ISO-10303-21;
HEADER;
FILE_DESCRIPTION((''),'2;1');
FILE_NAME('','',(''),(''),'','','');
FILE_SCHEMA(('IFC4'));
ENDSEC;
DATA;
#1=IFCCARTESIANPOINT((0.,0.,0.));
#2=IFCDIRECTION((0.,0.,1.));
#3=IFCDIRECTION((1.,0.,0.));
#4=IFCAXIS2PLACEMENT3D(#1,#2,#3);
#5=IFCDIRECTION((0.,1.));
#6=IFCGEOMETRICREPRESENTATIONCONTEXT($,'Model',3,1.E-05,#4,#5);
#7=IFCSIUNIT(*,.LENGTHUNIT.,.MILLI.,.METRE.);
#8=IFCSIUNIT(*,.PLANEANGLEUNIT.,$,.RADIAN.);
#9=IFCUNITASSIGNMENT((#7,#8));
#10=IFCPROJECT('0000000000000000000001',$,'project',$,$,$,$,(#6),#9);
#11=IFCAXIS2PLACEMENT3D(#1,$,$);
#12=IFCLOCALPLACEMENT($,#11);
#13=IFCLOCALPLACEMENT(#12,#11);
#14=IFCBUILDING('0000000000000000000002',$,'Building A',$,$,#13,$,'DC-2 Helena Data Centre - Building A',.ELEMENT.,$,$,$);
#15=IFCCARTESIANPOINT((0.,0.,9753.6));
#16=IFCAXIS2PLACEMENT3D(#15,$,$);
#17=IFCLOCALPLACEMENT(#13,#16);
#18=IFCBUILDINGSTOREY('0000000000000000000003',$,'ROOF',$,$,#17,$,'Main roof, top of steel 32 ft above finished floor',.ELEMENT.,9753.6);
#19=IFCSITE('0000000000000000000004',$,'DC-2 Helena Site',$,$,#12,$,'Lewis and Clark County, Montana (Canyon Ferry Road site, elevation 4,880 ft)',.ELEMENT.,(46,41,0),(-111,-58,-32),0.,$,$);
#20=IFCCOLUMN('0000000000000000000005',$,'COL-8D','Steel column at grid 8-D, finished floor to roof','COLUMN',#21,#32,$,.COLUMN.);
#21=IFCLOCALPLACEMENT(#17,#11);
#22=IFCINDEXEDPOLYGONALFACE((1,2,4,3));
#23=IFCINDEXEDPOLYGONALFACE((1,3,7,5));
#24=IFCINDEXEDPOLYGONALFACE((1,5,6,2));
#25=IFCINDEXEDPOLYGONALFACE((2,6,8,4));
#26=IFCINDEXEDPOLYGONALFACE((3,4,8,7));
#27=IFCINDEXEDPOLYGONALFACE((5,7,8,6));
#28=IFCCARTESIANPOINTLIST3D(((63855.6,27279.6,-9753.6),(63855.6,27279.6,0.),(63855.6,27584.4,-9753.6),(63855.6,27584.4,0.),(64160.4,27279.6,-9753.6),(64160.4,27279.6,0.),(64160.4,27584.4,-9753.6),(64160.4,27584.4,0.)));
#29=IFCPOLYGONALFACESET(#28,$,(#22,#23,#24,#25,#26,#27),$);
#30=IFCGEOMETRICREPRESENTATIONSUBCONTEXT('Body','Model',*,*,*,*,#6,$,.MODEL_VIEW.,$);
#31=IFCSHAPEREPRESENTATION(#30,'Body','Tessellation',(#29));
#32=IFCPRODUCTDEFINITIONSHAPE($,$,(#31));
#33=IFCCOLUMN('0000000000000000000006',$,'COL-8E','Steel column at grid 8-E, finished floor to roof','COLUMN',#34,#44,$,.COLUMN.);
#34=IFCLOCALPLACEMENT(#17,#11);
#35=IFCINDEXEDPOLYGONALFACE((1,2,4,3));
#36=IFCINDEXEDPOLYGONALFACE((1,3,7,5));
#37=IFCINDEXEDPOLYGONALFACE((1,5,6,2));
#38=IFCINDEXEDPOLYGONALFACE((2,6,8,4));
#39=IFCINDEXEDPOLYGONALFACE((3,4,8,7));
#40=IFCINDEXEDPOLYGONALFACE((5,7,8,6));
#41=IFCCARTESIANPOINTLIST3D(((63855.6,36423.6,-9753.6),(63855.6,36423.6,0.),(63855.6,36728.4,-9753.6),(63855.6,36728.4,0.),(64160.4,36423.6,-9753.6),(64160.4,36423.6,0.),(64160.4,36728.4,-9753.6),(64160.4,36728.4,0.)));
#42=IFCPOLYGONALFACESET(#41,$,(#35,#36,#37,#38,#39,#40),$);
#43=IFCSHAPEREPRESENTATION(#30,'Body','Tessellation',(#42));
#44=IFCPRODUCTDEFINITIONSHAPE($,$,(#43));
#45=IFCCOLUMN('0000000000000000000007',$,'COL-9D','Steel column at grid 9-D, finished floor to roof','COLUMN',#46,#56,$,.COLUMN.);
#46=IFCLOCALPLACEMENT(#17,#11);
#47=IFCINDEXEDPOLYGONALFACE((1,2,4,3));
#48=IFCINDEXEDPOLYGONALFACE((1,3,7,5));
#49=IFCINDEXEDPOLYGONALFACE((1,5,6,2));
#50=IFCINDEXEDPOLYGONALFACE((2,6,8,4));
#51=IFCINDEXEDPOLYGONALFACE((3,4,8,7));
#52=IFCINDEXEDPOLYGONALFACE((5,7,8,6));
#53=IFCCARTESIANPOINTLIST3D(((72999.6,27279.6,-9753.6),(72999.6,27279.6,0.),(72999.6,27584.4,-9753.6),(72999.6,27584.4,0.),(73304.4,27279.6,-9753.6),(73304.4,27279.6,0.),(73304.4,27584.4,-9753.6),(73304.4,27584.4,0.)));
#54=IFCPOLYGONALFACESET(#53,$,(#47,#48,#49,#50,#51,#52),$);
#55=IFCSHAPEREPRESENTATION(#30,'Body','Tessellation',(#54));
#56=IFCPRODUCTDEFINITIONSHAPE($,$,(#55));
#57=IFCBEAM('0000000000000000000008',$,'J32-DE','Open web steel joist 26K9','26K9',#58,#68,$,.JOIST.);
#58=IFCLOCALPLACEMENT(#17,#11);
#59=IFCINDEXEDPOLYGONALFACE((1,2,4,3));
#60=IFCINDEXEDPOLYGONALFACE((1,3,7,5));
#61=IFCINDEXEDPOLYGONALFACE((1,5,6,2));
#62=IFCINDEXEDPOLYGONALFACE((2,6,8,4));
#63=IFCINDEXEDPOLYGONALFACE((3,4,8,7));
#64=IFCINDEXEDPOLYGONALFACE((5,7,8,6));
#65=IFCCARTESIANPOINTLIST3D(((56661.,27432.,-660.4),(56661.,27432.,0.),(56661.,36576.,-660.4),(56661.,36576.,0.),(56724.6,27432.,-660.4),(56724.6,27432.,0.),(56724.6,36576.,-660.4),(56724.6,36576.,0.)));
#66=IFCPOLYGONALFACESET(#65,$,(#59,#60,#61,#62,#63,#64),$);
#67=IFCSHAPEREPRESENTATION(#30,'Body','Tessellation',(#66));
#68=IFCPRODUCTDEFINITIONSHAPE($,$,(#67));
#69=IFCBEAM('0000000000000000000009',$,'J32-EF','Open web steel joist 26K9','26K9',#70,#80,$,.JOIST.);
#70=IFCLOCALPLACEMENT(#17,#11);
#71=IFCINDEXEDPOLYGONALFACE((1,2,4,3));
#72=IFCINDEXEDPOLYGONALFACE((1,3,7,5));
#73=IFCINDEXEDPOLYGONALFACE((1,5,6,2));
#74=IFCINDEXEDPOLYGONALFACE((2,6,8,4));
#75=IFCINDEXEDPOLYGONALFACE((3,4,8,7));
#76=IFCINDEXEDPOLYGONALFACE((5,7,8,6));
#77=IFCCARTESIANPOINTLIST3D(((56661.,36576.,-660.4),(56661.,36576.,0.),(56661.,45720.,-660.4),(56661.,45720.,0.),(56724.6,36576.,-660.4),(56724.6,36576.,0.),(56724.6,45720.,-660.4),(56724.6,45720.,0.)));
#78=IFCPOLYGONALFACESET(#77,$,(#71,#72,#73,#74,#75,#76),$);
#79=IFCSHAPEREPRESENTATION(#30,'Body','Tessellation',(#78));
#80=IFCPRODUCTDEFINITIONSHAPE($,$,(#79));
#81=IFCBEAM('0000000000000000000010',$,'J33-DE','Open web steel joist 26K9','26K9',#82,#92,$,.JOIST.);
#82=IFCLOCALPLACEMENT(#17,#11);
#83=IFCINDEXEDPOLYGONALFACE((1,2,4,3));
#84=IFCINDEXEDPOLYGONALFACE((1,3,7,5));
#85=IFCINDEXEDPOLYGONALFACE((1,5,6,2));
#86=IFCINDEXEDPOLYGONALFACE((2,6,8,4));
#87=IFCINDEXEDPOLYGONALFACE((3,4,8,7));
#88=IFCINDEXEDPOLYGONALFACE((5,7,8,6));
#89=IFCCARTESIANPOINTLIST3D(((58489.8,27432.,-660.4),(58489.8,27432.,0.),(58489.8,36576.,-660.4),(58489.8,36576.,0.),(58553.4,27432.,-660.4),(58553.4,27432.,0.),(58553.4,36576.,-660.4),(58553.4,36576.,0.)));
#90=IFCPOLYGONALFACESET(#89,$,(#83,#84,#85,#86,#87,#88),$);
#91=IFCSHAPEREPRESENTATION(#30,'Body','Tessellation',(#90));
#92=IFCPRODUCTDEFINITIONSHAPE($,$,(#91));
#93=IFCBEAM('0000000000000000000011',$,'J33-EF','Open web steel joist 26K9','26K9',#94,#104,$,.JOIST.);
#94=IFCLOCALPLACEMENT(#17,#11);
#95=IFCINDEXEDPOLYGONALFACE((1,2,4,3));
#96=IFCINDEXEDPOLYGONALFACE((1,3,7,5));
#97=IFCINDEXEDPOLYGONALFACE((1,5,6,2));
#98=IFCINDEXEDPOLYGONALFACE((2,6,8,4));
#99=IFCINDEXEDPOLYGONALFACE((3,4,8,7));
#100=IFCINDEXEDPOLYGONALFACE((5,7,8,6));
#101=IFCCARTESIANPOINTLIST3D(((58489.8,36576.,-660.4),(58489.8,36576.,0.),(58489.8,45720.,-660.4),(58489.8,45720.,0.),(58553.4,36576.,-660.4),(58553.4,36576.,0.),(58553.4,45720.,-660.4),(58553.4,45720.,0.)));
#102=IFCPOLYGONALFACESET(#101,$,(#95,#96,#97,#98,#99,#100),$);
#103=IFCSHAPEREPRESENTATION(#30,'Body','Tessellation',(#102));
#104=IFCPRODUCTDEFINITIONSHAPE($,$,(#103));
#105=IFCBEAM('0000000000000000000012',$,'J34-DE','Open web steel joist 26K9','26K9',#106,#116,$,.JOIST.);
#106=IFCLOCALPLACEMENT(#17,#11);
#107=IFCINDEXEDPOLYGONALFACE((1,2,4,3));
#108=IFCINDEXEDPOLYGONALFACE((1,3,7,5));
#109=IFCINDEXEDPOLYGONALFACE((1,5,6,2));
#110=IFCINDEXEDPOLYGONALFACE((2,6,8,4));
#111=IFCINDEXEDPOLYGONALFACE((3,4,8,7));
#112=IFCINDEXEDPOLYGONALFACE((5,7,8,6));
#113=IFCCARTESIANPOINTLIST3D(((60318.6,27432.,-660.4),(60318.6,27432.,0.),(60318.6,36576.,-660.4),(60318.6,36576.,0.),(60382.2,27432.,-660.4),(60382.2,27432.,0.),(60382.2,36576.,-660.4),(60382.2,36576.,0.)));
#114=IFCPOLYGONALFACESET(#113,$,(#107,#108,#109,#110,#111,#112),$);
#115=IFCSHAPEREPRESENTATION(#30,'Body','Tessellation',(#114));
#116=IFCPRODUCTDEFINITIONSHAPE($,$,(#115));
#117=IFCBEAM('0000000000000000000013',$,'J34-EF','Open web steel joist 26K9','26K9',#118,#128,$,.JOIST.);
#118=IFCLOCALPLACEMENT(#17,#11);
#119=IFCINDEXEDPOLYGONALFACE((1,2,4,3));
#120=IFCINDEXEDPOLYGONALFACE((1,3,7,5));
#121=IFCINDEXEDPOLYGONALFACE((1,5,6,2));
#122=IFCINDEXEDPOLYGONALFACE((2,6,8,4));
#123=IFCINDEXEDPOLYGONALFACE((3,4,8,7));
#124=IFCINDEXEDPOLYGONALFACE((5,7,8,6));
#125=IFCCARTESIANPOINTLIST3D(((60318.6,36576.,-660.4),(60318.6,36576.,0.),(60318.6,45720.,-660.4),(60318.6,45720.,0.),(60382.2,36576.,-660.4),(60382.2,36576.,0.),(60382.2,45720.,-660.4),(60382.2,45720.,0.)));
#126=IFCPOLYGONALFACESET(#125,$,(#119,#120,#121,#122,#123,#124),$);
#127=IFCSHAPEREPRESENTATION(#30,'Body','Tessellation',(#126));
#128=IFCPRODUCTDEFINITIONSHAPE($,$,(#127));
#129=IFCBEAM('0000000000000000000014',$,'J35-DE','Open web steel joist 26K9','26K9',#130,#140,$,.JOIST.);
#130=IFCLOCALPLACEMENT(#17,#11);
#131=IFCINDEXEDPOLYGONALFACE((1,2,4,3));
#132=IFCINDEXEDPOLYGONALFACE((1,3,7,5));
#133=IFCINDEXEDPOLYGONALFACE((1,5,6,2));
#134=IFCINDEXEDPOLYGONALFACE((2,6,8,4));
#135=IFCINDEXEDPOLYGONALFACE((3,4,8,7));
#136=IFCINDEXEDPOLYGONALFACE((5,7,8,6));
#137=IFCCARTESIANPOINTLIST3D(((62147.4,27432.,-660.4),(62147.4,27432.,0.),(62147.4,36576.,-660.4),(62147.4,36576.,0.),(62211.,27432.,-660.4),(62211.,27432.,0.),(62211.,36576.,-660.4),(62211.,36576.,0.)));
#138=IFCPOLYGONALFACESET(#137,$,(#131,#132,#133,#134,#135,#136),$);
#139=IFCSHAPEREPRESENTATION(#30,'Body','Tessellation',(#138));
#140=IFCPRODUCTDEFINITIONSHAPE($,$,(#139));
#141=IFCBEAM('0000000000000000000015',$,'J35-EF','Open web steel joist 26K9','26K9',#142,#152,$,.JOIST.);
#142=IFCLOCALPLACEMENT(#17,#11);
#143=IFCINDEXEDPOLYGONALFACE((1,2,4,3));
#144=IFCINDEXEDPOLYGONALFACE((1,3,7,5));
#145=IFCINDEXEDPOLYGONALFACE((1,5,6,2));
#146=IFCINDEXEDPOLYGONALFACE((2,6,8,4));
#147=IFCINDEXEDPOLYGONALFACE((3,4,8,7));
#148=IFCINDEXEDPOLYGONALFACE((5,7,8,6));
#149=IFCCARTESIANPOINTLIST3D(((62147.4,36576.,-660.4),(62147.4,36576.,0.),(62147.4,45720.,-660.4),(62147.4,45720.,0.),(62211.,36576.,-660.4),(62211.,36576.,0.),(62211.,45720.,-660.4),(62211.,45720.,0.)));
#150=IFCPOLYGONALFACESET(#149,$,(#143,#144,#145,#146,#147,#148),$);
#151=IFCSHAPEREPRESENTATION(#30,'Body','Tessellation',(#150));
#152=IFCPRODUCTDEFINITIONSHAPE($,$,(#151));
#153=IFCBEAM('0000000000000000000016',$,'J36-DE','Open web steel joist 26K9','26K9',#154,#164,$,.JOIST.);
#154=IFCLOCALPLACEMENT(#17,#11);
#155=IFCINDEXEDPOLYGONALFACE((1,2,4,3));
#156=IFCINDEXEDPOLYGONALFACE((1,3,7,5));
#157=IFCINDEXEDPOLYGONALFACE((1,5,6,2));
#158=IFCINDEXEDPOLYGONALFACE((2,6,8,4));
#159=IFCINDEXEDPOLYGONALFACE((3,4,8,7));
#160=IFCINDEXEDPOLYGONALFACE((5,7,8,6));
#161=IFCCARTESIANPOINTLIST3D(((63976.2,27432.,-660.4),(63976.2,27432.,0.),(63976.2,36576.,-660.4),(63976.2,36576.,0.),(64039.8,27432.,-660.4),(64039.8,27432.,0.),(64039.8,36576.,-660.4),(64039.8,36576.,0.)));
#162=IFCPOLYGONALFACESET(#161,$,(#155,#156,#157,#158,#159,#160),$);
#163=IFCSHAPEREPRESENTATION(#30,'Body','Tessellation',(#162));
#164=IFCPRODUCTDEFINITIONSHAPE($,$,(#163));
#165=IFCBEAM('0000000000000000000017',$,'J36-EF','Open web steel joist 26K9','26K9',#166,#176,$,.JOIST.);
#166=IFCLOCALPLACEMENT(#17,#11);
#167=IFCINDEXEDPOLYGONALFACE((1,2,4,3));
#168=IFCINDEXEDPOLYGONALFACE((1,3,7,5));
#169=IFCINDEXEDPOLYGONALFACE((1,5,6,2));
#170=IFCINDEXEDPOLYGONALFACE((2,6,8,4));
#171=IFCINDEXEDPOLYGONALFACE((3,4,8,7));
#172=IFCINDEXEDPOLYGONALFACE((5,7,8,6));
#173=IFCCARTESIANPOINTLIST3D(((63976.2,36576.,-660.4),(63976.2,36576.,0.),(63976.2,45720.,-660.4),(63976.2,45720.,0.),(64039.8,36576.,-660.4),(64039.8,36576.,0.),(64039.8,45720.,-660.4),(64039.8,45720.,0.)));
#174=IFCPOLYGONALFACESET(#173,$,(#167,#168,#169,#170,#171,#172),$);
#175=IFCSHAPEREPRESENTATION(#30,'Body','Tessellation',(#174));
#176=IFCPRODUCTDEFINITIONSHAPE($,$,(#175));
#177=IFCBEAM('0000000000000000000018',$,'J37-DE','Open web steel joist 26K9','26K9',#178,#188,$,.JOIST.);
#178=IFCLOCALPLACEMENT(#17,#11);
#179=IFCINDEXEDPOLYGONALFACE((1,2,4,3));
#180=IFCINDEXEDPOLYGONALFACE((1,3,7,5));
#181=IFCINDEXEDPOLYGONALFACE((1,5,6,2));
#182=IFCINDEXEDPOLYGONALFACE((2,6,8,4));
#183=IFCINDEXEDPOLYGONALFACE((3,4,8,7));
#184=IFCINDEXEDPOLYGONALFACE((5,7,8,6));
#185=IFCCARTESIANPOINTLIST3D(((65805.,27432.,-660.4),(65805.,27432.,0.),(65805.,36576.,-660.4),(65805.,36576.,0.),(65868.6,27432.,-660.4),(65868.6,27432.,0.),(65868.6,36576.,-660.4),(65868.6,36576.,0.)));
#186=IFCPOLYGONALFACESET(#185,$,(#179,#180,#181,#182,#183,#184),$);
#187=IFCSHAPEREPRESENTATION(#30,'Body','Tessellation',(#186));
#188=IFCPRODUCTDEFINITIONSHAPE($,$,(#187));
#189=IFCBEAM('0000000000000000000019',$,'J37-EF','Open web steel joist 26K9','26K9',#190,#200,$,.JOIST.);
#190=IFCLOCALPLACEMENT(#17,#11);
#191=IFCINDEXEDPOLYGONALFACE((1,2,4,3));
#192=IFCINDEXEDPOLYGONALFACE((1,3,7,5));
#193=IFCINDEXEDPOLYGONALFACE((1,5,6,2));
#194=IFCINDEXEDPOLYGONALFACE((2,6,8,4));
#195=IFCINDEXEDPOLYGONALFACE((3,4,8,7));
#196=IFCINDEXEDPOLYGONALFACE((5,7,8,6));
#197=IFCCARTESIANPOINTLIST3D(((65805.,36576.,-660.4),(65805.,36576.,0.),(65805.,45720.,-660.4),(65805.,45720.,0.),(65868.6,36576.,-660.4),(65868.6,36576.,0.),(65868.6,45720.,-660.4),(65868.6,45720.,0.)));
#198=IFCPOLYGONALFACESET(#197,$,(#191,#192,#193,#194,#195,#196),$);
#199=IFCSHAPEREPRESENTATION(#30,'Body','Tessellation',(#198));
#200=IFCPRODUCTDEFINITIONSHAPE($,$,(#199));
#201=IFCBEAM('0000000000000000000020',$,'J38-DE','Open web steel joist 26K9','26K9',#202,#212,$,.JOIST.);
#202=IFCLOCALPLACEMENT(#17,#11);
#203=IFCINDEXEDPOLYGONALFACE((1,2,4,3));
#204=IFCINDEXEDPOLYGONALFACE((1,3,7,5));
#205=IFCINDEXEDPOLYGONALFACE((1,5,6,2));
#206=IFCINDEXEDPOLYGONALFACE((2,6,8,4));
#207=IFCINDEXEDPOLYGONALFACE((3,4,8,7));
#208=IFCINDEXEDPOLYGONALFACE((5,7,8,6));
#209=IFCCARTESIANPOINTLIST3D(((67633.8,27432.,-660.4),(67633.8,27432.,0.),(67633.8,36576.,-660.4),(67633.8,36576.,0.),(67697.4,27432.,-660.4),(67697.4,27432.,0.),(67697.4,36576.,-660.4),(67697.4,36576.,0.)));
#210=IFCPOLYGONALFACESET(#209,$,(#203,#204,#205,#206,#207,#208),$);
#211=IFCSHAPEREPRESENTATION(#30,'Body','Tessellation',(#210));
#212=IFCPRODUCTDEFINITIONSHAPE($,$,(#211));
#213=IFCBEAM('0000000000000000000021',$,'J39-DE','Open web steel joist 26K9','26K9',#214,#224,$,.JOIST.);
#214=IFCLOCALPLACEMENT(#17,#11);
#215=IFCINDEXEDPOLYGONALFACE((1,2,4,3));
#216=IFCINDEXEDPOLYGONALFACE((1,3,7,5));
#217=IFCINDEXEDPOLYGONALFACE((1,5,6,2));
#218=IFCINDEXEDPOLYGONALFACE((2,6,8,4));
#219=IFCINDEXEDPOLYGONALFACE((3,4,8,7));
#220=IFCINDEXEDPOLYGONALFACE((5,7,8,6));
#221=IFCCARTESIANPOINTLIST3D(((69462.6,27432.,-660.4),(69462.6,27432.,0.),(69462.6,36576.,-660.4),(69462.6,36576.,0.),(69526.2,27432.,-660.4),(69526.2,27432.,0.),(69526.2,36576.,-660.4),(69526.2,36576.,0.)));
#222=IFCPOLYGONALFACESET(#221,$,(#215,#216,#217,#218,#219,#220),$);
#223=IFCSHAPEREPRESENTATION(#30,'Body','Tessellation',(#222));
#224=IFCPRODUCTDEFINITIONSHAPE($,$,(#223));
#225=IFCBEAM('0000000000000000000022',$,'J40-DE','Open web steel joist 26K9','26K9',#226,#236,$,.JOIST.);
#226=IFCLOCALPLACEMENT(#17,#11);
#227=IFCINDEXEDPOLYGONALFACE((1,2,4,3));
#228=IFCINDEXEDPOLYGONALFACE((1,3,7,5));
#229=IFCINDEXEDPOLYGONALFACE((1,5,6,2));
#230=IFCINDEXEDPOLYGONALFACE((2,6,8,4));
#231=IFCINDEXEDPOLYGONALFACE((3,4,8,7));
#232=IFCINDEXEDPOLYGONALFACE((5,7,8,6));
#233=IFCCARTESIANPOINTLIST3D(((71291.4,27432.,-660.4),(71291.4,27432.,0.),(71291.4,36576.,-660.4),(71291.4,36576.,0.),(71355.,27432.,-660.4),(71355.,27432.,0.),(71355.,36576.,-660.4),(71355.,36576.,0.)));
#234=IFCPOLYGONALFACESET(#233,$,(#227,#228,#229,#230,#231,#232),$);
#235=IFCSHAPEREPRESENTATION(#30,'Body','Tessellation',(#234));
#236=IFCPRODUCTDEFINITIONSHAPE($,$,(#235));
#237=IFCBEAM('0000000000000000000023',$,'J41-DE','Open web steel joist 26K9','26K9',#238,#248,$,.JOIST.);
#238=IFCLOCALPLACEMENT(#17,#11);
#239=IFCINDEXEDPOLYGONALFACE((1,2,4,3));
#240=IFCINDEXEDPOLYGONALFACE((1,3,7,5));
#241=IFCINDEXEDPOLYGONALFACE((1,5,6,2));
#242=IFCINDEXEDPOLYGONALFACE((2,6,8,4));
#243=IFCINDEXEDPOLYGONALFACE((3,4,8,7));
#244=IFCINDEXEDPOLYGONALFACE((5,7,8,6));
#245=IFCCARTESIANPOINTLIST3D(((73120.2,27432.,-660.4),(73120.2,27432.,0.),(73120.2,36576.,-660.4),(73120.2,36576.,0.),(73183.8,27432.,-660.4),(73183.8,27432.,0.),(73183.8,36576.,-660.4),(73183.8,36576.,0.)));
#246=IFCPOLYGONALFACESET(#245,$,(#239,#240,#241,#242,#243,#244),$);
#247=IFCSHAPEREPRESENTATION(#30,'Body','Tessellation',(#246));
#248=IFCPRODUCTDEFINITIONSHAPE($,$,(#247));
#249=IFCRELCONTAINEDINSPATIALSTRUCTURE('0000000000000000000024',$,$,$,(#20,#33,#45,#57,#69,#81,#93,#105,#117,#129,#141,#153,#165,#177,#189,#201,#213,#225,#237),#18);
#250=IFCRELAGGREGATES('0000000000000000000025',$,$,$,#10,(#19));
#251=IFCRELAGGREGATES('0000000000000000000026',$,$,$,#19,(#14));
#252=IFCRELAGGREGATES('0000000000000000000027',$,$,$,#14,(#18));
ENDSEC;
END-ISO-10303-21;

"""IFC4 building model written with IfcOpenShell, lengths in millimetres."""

from ifc_helpers import new_model, si_unit, direction, frame, origin, origin_with_axes, origin_2d, place, context, subcontext, project, spatial, rectangle, extrude, element, save


model = new_model("IFC4")

# Units and contexts
model_context = context("Model", 3, precision=1e-05, world=origin_with_axes(), true_north=direction((0.0, 1.0)))
body_context = subcontext(model_context, "Body", "Model", "MODEL_VIEW")
ifc_project = project(units=[si_unit("LENGTHUNIT", "METRE", prefix="MILLI"), si_unit("PLANEANGLEUNIT", "RADIAN")], contexts=[model_context])

# Site, building, storey
site_placement = place(None, origin())
site = spatial("IfcSite", under=ifc_project, at=site_placement, Name="DC-2 Helena Site", LongName="Lewis and Clark County, Montana (Canyon Ferry Road site, elevation 4,880 ft)", CompositionType="ELEMENT", RefLatitude=(46, 41, 0), RefLongitude=(-111, -58, -32), RefElevation=0.0)
building_placement = place(site_placement, origin())
building = spatial("IfcBuilding", under=site, at=building_placement, Name="Building A", LongName="DC-2 Helena Data Centre - Building A", CompositionType="ELEMENT")
storey_placement = place(building_placement, frame((0.0, 0.0, 9753.6)))
storey = spatial("IfcBuildingStorey", under=building, at=storey_placement, Name="ROOF", LongName="Main roof, top of steel 32 ft above finished floor", CompositionType="ELEMENT", Elevation=9753.6)

# Columns
for number, where, name, description in (
    (1, (64008.0, 27432.0, -9753.6), "COL-8D", "Steel column at grid 8-D, finished floor to roof"),
    (2, (64008.0, 36576.0, -9753.6), "COL-8E", "Steel column at grid 8-E, finished floor to roof"),
):
    element("IfcColumn", number, at=place(storey_placement, frame(where)), inside=storey, Name=name, Description=description, ObjectType="COLUMN", PredefinedType="COLUMN", context=body_context, shape_type="SweptSolid", body=[
        extrude(rectangle(XDim=304.8, YDim=304.8, at=origin_2d()), origin(), (0.0, 0.0, 1.0), 9753.6),
    ])
placement_1 = place(storey_placement, frame((73152.0, 27432.0, -9753.6)))
element("IfcColumn", 3, at=placement_1, inside=storey, Name="COL-9D", Description="Steel column at grid 9-D, finished floor to roof", ObjectType="COLUMN", PredefinedType="COLUMN", context=body_context, shape_type="SweptSolid", body=[
    extrude(rectangle(XDim=304.8, YDim=304.8, at=origin_2d()), origin(), (0.0, 0.0, 1.0), 9753.6),
])

# Beams
for number, where, name in (
    (4, (56692.8, 27432.0, 0.0), "J32-DE"),
    (5, (56692.8, 36576.0, 0.0), "J32-EF"),
    (6, (58521.6, 27432.0, 0.0), "J33-DE"),
    (7, (58521.6, 36576.0, 0.0), "J33-EF"),
    (8, (60350.4, 27432.0, 0.0), "J34-DE"),
    (9, (60350.4, 36576.0, 0.0), "J34-EF"),
    (10, (62179.2, 27432.0, 0.0), "J35-DE"),
    (11, (62179.2, 36576.0, 0.0), "J35-EF"),
):
    element("IfcBeam", number, at=place(storey_placement, frame(where)), inside=storey, Name=name, Description="Open web steel joist 26K9", ObjectType="26K9", PredefinedType="JOIST", context=body_context, shape_type="SweptSolid", body=[
        extrude(rectangle(XDim=63.5, YDim=660.4, at=origin_2d()), frame((0.0, 0.0, -330.2), z_axis=(0.0, 1.0, 0.0), x_axis=(1.0, 0.0, 0.0)), (0.0, 0.0, 1.0), 9144.0),
    ])
placement_2 = place(storey_placement, frame((64008.0, 27432.0, 0.0)))
element("IfcBeam", 12, at=placement_2, inside=storey, Name="J36-DE", Description="Open web steel joist 26K9", ObjectType="26K9", PredefinedType="JOIST", context=body_context, shape_type="SweptSolid", body=[
    extrude(rectangle(XDim=63.5, YDim=660.4, at=origin_2d()), frame((0.0, 0.0, -330.2), z_axis=(0.0, 1.0, 0.0), x_axis=(1.0, 0.0, 0.0)), (0.0, 0.0, 1.0), 9144.0),
])
placement_3 = place(storey_placement, frame((64008.0, 36576.0, 0.0)))
element("IfcBeam", 13, at=placement_3, inside=storey, Name="J36-EF", Description="Open web steel joist 26K9", ObjectType="26K9", PredefinedType="JOIST", context=body_context, shape_type="SweptSolid", body=[
    extrude(rectangle(XDim=63.5, YDim=660.4, at=origin_2d()), frame((0.0, 0.0, -330.2), z_axis=(0.0, 1.0, 0.0), x_axis=(1.0, 0.0, 0.0)), (0.0, 0.0, 1.0), 9144.0),
])
for number, where, name in (
    (14, (65836.8, 27432.0, 0.0), "J37-DE"),
    (15, (65836.8, 36576.0, 0.0), "J37-EF"),
    (16, (67665.6, 27432.0, 0.0), "J38-DE"),
    (17, (69494.4, 27432.0, 0.0), "J39-DE"),
    (18, (71323.2, 27432.0, 0.0), "J40-DE"),
    (19, (73152.0, 27432.0, 0.0), "J41-DE"),
):
    element("IfcBeam", number, at=place(storey_placement, frame(where)), inside=storey, Name=name, Description="Open web steel joist 26K9", ObjectType="26K9", PredefinedType="JOIST", context=body_context, shape_type="SweptSolid", body=[
        extrude(rectangle(XDim=63.5, YDim=660.4, at=origin_2d()), frame((0.0, 0.0, -330.2), z_axis=(0.0, 1.0, 0.0), x_axis=(1.0, 0.0, 0.0)), (0.0, 0.0, 1.0), 9144.0),
    ])

save(model, "model.ifc")
